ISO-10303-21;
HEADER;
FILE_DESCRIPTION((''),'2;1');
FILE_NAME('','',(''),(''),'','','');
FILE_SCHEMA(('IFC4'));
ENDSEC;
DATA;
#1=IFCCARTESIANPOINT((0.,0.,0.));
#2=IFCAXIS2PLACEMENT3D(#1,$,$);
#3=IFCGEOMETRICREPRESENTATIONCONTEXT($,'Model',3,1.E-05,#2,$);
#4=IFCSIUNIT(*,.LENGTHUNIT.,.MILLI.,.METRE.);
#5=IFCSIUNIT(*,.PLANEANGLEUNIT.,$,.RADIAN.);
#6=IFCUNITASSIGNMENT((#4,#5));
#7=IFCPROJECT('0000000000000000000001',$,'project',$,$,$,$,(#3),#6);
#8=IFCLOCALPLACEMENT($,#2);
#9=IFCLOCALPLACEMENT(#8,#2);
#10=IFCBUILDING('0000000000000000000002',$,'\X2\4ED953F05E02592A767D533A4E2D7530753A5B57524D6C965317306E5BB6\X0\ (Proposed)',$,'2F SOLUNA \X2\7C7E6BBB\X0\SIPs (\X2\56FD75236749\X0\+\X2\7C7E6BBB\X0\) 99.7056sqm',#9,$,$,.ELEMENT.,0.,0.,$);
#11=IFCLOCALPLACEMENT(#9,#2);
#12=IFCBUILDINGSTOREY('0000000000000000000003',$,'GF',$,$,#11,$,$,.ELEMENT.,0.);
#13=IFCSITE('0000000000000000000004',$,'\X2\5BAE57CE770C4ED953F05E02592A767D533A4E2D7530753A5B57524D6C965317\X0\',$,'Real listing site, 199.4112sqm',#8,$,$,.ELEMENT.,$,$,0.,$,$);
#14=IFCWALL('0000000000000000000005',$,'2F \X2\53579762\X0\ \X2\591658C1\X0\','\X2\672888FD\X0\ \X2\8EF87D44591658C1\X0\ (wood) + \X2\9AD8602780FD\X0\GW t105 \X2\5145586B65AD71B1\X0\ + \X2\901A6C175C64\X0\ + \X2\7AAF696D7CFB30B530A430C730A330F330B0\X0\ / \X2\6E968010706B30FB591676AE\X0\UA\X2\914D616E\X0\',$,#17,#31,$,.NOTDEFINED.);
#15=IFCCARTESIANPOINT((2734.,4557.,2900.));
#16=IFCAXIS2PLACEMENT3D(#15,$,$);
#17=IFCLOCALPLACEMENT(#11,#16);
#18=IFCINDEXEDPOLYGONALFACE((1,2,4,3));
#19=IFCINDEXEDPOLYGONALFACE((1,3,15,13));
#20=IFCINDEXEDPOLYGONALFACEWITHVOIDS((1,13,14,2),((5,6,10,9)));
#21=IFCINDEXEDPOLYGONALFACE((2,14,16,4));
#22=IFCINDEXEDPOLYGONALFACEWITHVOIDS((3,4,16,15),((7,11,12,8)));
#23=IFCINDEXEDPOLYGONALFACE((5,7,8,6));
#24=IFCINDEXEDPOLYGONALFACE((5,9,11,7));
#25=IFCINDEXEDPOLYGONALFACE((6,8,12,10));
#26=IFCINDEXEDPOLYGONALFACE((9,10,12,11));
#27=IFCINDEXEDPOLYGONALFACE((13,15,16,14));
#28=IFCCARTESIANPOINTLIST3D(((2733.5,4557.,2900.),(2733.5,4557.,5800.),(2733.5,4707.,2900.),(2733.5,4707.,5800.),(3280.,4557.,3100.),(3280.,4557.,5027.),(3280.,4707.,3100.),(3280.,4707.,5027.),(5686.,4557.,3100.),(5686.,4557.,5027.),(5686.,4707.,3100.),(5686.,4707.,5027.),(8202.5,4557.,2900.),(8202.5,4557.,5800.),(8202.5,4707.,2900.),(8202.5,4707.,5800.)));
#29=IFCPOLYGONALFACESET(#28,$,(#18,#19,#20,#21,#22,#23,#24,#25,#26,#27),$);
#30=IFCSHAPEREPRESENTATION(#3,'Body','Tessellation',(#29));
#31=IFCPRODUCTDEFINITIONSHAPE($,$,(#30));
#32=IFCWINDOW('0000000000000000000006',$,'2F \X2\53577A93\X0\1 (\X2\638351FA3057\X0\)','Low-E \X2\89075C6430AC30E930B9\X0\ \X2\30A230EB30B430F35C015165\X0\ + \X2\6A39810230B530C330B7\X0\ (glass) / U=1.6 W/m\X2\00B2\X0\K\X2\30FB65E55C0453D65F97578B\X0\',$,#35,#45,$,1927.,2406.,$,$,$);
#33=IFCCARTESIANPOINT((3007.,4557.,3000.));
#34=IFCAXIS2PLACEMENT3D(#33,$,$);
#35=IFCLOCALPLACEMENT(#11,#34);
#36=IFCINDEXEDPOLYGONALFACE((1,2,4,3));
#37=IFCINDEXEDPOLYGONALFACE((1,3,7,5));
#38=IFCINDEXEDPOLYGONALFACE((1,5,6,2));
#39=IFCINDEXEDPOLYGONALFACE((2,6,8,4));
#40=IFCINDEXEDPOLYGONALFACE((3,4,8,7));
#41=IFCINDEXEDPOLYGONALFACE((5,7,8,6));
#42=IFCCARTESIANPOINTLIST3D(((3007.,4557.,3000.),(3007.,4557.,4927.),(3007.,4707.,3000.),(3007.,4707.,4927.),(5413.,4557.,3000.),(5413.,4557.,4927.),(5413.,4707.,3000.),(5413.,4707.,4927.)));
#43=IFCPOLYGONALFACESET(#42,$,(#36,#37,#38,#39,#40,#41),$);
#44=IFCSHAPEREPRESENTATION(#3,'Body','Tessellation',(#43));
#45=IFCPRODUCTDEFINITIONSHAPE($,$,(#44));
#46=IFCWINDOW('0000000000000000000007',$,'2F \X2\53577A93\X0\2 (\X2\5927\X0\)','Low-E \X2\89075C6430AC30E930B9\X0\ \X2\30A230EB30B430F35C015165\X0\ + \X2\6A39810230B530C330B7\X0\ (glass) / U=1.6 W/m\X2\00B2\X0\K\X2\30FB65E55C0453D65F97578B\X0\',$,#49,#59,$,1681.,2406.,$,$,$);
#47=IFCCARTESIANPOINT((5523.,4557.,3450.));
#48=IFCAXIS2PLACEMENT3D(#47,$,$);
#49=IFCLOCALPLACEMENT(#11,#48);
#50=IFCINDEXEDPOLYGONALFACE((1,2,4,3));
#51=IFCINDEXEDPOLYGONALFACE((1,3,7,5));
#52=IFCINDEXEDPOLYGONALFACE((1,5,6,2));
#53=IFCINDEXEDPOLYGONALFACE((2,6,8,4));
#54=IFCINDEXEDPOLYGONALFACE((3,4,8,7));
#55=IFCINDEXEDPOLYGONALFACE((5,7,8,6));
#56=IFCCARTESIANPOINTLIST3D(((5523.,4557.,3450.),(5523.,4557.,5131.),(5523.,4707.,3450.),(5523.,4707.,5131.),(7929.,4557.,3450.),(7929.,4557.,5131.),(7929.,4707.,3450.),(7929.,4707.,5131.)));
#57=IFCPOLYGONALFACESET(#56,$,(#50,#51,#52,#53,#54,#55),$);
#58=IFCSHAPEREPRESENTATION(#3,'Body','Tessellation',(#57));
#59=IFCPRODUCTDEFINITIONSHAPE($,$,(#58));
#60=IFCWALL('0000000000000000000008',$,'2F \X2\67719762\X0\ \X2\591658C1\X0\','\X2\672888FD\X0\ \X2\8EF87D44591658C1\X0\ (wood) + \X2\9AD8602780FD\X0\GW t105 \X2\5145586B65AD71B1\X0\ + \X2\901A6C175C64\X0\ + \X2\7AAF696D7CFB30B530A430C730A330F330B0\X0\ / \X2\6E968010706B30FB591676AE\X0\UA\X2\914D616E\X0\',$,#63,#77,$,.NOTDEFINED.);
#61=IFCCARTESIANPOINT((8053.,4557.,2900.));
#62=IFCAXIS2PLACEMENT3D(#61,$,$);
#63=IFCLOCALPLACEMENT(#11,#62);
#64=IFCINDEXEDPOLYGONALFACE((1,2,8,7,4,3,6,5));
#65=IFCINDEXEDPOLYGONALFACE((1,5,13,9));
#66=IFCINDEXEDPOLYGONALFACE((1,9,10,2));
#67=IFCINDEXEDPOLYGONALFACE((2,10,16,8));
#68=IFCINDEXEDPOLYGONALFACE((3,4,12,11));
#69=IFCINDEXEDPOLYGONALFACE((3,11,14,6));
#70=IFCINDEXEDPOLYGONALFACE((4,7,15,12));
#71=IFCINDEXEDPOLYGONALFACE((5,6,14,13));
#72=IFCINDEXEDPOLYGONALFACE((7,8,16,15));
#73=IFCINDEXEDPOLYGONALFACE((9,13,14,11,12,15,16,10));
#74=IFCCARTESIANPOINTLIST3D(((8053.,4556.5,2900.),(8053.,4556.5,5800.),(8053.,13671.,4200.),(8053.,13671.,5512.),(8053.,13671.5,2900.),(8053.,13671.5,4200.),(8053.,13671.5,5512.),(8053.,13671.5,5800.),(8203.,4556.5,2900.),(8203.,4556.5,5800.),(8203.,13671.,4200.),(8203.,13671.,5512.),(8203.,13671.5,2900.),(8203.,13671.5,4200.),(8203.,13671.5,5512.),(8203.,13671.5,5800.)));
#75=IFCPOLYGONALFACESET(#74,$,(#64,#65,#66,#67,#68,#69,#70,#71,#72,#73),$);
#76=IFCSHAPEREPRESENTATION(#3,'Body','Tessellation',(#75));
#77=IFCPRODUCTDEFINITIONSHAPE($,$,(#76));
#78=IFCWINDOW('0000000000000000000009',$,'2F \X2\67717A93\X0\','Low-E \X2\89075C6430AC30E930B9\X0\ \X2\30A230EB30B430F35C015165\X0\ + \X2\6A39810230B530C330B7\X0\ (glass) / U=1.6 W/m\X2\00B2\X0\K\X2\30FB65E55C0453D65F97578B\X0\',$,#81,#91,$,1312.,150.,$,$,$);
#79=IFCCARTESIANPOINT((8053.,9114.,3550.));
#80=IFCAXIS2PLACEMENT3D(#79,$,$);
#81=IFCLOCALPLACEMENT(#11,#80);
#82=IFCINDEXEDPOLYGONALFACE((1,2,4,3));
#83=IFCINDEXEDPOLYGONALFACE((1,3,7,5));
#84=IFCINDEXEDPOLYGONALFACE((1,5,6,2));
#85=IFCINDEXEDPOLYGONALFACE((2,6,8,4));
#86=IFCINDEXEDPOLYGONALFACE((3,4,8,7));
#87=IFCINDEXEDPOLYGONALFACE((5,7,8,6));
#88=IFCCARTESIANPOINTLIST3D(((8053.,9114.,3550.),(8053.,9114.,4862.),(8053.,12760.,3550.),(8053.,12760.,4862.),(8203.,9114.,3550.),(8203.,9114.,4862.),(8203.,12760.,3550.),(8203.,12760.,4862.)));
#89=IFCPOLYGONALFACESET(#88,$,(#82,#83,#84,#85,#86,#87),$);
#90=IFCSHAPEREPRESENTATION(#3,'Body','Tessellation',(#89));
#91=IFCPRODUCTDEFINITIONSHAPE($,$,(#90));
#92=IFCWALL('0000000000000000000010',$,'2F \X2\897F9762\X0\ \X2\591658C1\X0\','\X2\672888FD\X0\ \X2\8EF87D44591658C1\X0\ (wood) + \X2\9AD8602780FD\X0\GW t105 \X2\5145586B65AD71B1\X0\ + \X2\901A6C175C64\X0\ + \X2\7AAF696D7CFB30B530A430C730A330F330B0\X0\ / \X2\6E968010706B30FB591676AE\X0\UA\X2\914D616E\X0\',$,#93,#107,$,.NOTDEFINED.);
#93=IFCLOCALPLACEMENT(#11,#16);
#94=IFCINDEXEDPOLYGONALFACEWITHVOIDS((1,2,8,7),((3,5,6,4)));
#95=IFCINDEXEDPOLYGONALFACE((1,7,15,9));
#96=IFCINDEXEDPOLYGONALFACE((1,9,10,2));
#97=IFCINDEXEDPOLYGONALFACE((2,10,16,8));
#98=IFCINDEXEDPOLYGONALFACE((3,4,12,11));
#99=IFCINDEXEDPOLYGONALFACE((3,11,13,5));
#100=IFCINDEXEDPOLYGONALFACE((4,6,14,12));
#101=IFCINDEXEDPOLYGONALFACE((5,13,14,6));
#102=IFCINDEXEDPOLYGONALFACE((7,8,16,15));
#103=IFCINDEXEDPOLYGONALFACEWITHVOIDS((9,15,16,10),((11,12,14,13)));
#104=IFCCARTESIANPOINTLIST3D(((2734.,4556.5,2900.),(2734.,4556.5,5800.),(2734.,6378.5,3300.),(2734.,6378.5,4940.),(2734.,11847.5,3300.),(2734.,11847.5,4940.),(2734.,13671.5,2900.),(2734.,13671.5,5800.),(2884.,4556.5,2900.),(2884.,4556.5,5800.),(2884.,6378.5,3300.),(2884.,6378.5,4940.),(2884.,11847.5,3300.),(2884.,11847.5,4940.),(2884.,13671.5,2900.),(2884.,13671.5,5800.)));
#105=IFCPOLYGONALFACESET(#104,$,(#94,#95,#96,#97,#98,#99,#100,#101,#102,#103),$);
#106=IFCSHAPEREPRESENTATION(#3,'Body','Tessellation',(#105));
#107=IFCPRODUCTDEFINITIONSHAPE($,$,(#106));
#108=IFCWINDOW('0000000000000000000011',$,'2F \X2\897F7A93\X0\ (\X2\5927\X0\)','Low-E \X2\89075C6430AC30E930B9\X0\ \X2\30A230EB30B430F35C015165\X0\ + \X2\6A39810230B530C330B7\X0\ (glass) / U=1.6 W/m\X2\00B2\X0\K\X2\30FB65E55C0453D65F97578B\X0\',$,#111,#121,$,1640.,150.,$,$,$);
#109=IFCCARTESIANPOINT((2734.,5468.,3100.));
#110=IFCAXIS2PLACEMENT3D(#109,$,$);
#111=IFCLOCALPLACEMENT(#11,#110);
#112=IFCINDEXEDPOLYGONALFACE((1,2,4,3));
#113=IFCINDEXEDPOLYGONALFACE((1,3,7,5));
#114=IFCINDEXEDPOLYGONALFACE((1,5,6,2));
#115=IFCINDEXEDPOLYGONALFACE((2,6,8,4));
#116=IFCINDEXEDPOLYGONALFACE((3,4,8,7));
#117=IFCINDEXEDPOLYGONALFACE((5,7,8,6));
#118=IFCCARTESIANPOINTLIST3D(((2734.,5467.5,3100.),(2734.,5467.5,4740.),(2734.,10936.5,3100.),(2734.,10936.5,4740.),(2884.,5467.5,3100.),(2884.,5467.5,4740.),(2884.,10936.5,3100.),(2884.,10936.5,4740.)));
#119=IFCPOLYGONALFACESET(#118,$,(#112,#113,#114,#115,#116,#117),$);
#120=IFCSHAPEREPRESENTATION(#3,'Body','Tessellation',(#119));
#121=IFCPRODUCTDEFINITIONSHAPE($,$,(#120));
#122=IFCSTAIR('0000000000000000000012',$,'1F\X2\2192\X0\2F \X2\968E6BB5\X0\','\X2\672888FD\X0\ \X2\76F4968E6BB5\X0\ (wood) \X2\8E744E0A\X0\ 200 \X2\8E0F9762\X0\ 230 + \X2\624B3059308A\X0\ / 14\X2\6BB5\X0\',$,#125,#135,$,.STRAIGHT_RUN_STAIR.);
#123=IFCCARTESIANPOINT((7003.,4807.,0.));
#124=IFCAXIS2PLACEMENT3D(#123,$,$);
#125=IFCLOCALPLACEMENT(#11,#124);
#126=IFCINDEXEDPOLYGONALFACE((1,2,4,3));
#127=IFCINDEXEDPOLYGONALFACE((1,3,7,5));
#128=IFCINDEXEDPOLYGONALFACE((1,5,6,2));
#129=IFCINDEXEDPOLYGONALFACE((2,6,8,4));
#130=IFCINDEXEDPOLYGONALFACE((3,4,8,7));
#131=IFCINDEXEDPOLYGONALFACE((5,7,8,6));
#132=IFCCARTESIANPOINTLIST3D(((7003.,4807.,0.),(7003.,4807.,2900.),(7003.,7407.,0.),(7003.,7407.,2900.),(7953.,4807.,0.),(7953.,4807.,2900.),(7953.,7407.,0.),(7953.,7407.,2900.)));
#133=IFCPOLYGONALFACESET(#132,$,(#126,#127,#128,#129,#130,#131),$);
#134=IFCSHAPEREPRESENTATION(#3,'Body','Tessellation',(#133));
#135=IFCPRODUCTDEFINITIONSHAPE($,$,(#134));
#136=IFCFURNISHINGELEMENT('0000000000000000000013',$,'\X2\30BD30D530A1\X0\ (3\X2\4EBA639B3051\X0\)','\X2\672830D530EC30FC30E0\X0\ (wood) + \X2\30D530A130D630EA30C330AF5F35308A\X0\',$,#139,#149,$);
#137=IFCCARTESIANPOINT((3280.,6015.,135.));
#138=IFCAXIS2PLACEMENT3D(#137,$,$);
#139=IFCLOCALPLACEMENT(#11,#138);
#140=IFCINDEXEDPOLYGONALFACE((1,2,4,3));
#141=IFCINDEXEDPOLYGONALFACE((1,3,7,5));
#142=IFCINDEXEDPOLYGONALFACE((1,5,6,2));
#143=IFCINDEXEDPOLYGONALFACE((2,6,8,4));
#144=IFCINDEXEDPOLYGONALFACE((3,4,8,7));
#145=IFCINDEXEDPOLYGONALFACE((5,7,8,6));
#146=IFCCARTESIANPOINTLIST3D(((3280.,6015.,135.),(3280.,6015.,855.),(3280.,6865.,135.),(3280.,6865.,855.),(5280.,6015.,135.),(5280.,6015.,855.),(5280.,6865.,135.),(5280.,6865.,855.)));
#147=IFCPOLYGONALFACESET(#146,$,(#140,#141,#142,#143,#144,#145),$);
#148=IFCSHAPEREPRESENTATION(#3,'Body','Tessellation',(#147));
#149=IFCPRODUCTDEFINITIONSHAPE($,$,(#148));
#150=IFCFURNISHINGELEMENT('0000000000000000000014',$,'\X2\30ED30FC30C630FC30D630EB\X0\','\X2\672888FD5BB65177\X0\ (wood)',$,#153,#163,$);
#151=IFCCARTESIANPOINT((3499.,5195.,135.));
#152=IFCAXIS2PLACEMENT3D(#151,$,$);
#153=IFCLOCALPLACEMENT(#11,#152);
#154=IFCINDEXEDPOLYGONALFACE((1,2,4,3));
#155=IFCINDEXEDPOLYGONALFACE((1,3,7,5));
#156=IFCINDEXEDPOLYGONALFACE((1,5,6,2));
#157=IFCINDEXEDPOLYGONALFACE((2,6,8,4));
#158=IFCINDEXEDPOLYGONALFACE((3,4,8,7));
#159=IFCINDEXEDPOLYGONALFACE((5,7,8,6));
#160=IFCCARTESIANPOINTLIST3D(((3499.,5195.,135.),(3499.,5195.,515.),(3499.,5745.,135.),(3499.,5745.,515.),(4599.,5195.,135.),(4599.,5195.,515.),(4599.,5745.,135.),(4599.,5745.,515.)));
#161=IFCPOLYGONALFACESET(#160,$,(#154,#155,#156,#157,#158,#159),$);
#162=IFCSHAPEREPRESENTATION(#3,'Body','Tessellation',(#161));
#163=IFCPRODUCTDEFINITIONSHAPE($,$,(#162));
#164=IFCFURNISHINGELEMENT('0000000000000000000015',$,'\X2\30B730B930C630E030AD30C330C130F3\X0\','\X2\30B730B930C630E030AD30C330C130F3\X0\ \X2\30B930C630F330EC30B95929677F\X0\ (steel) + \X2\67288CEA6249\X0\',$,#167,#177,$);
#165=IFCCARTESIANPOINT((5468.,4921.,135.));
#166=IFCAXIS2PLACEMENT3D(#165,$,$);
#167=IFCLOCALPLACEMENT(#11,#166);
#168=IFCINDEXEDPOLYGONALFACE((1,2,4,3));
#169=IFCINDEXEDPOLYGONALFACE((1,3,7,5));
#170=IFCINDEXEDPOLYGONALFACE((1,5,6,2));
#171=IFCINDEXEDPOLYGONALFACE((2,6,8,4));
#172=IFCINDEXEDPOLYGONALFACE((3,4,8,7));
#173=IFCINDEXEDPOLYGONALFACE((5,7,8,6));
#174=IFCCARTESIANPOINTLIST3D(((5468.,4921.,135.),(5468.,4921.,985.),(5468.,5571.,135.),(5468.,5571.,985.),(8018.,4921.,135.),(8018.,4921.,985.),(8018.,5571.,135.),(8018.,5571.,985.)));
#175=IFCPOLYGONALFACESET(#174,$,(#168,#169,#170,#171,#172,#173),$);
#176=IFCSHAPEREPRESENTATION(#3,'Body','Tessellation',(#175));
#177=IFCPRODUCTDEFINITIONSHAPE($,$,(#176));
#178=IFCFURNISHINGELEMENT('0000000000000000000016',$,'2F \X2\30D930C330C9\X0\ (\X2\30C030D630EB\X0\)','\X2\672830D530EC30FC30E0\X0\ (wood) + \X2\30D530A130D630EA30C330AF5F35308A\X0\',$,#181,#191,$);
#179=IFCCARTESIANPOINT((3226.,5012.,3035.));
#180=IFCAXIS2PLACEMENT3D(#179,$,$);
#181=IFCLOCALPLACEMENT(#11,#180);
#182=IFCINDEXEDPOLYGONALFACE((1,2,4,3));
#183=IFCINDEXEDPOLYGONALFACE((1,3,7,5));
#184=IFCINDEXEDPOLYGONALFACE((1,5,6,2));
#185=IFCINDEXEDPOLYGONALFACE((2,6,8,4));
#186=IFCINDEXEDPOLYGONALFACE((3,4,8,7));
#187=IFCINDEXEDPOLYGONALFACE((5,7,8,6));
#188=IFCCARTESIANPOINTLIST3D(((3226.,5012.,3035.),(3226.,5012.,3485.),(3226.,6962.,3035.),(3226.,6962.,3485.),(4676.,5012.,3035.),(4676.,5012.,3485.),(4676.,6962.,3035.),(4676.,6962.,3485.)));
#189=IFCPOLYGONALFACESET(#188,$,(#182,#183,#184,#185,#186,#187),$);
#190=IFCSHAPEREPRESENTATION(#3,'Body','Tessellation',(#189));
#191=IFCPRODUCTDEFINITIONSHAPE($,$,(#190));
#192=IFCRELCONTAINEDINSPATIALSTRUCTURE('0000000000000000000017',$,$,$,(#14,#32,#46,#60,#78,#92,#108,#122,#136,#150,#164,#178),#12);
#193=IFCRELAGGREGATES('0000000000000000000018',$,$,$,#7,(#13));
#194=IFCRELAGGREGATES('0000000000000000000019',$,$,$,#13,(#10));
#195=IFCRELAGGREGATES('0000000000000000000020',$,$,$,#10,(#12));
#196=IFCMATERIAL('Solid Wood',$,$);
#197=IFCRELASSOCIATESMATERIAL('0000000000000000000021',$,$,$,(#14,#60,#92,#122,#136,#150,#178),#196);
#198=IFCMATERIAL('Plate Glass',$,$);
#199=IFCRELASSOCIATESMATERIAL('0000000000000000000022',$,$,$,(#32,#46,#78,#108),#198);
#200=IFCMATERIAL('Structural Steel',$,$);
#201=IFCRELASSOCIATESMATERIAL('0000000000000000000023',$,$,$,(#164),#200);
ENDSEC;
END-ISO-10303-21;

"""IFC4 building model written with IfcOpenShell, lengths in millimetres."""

from ifc_helpers import new_model, si_unit, frame, frame_2d, origin, place, context, project, spatial, rectangle, extrude, material, element, fill, save


model = new_model("IFC4")

# Units and contexts
model_context = context("Model", 3, precision=1e-05, world=origin())
ifc_project = project(units=[si_unit("LENGTHUNIT", "METRE", prefix="MILLI"), si_unit("PLANEANGLEUNIT", "RADIAN")], contexts=[model_context])

# Site, building, storey
site_placement = place(None, origin())
site = spatial("IfcSite", under=ifc_project, at=site_placement, Name="宮城県仙台市太白区中田町字前沖北", ObjectType="Real listing site, 199.4112sqm", CompositionType="ELEMENT", RefElevation=0.0)
building_placement = place(site_placement, origin())
building = spatial("IfcBuilding", under=site, at=building_placement, Name="仙台市太白区中田町字前沖北の家 (Proposed)", ObjectType="2F SOLUNA 籾殻SIPs (国産杉+籾殻) 99.7056sqm", CompositionType="ELEMENT", ElevationOfRefHeight=0.0, ElevationOfTerrain=0.0)
storey_placement = place(building_placement, origin())
storey = spatial("IfcBuildingStorey", under=building, at=storey_placement, Name="GF", CompositionType="ELEMENT", Elevation=0.0)

# Shared definitions
ifc_material_1 = material(Name="Solid Wood")

# Shared definitions
ifc_material_2 = material(Name="Plate Glass")

# Wall, openings, windows
wall_1_placement = place(storey_placement, frame((2734.0, 4557.0, 2900.0)))
wall_1 = element("IfcWall", 1, at=wall_1_placement, inside=storey, material=ifc_material_1, Name="2F 南面 外壁", Description="木製 軸組外壁 (wood) + 高性能GW t105 充填断熱 + 通気層 + 窯業系サイディング / 準耐火・外皮UA配慮", PredefinedType="NOTDEFINED", context=model_context, shape_type="SweptSolid", body=[
    extrude(rectangle(XDim=5469.0, YDim=150.0, at=frame_2d((2734.0, 75.0))), frame((2734.0, 4557.0, 2900.0)), (0.0, 0.0, 1.0), 2900.0),
])
opening_1_placement = place(storey_placement, frame((3007.0, 4557.0, 3000.0)))
opening_1 = element("IfcOpeningElement", 2, at=opening_1_placement, cuts=wall_1, PredefinedType="NOTDEFINED", context=model_context, shape_type="SweptSolid", body=[
    extrude(rectangle(XDim=2406.0, YDim=150.0, at=frame_2d((1203.0, 75.0))), frame((3007.0, 4557.0, 3000.0)), (0.0, 0.0, 1.0), 1927.0),
])
opening_2_placement = place(storey_placement, frame((5523.0, 4557.0, 3450.0)))
opening_2 = element("IfcOpeningElement", 3, at=opening_2_placement, cuts=wall_1, PredefinedType="NOTDEFINED", context=model_context, shape_type="SweptSolid", body=[
    extrude(rectangle(XDim=2406.0, YDim=150.0, at=frame_2d((1203.0, 75.0))), frame((5523.0, 4557.0, 3450.0)), (0.0, 0.0, 1.0), 1681.0),
])
window_1_placement = place(storey_placement, frame((3007.0, 4557.0, 3000.0)))
window_1 = element("IfcWindow", 4, at=window_1_placement, inside=storey, material=ifc_material_2, Name="2F 南窓1 (掃出し)", Description="Low-E 複層ガラス アルゴン封入 + 樹脂サッシ (glass) / U=1.6 W/m²K・日射取得型", OverallHeight=1927.0, OverallWidth=2406.0, context=model_context, shape_type="SweptSolid", body=[
    extrude(rectangle(XDim=2406.0, YDim=150.0, at=frame_2d((1203.0, 75.0))), frame((3007.0, 4557.0, 3000.0)), (0.0, 0.0, 1.0), 1927.0),
])
fill(opening_1, window_1)
window_2_placement = place(storey_placement, frame((5523.0, 4557.0, 3450.0)))
window_2 = element("IfcWindow", 5, at=window_2_placement, inside=storey, material=ifc_material_2, Name="2F 南窓2 (大)", Description="Low-E 複層ガラス アルゴン封入 + 樹脂サッシ (glass) / U=1.6 W/m²K・日射取得型", OverallHeight=1681.0, OverallWidth=2406.0, context=model_context, shape_type="SweptSolid", body=[
    extrude(rectangle(XDim=2406.0, YDim=150.0, at=frame_2d((1203.0, 75.0))), frame((5523.0, 4557.0, 3450.0)), (0.0, 0.0, 1.0), 1681.0),
])
fill(opening_2, window_2)

# Walls, openings, windows
wall_2_placement = place(storey_placement, frame((8053.0, 4557.0, 2900.0)))
wall_2 = element("IfcWall", 6, at=wall_2_placement, inside=storey, material=ifc_material_1, Name="2F 東面 外壁", Description="木製 軸組外壁 (wood) + 高性能GW t105 充填断熱 + 通気層 + 窯業系サイディング / 準耐火・外皮UA配慮", PredefinedType="NOTDEFINED", context=model_context, shape_type="SweptSolid", body=[
    extrude(rectangle(XDim=150.0, YDim=9115.0, at=frame_2d((75.0, 4557.0))), frame((8053.0, 4557.0, 2900.0)), (0.0, 0.0, 1.0), 2900.0),
])
opening_3_placement = place(storey_placement, frame((8053.0, 9114.0, 3550.0)))
opening_3 = element("IfcOpeningElement", 7, at=opening_3_placement, cuts=wall_2, PredefinedType="NOTDEFINED", context=model_context, shape_type="SweptSolid", body=[
    extrude(rectangle(XDim=150.0, YDim=3646.0, at=frame_2d((75.0, 1823.0))), frame((8053.0, 9114.0, 3550.0)), (0.0, 0.0, 1.0), 1312.0),
])
window_3_placement = place(storey_placement, frame((8053.0, 9114.0, 3550.0)))
window_3 = element("IfcWindow", 8, at=window_3_placement, inside=storey, material=ifc_material_2, Name="2F 東窓", Description="Low-E 複層ガラス アルゴン封入 + 樹脂サッシ (glass) / U=1.6 W/m²K・日射取得型", OverallHeight=1312.0, OverallWidth=150.0, context=model_context, shape_type="SweptSolid", body=[
    extrude(rectangle(XDim=150.0, YDim=3646.0, at=frame_2d((75.0, 1823.0))), frame((8053.0, 9114.0, 3550.0)), (0.0, 0.0, 1.0), 1312.0),
])
fill(opening_3, window_3)
wall_3_placement = place(storey_placement, frame((2734.0, 4557.0, 2900.0)))
wall_3 = element("IfcWall", 9, at=wall_3_placement, inside=storey, material=ifc_material_1, Name="2F 西面 外壁", Description="木製 軸組外壁 (wood) + 高性能GW t105 充填断熱 + 通気層 + 窯業系サイディング / 準耐火・外皮UA配慮", PredefinedType="NOTDEFINED", context=model_context, shape_type="SweptSolid", body=[
    extrude(rectangle(XDim=150.0, YDim=9115.0, at=frame_2d((75.0, 4557.0))), frame((2734.0, 4557.0, 2900.0)), (0.0, 0.0, 1.0), 2900.0),
])
opening_4_placement = place(storey_placement, frame((2734.0, 5468.0, 3100.0)))
opening_4 = element("IfcOpeningElement", 10, at=opening_4_placement, cuts=wall_3, PredefinedType="NOTDEFINED", context=model_context, shape_type="SweptSolid", body=[
    extrude(rectangle(XDim=150.0, YDim=5469.0, at=frame_2d((75.0, 2734.0))), frame((2734.0, 5468.0, 3100.0)), (0.0, 0.0, 1.0), 1640.0),
])
window_4_placement = place(storey_placement, frame((2734.0, 5468.0, 3100.0)))
window_4 = element("IfcWindow", 11, at=window_4_placement, inside=storey, material=ifc_material_2, Name="2F 西窓 (大)", Description="Low-E 複層ガラス アルゴン封入 + 樹脂サッシ (glass) / U=1.6 W/m²K・日射取得型", OverallHeight=1640.0, OverallWidth=150.0, context=model_context, shape_type="SweptSolid", body=[
    extrude(rectangle(XDim=150.0, YDim=5469.0, at=frame_2d((75.0, 2734.0))), frame((2734.0, 5468.0, 3100.0)), (0.0, 0.0, 1.0), 1640.0),
])
fill(opening_4, window_4)

# Stair
stair_placement = place(storey_placement, frame((7003.0, 4807.0, 0.0)))
element("IfcStair", 12, at=stair_placement, inside=storey, material=ifc_material_1, Name="1F→2F 階段", Description="木製 直階段 (wood) 蹴上 200 踏面 230 + 手すり / 14段", PredefinedType="STRAIGHT_RUN_STAIR", context=model_context, shape_type="SweptSolid", body=[
    extrude(rectangle(XDim=950.0, YDim=2600.0, at=frame_2d((475.0, 1300.0))), frame((7003.0, 4807.0, 0.0)), (0.0, 0.0, 1.0), 2900.0),
])

# Shared definitions
ifc_material_3 = material(Name="Structural Steel")

# Furnishing elements
furnishing_1_placement = place(storey_placement, frame((3280.0, 6015.0, 135.0)))
element("IfcFurnishingElement", 13, at=furnishing_1_placement, inside=storey, material=ifc_material_1, Name="ソファ (3人掛け)", Description="木フレーム (wood) + ファブリック張り", context=model_context, shape_type="SweptSolid", body=[
    extrude(rectangle(XDim=2000.0, YDim=850.0, at=frame_2d((1000.0, 425.0))), frame((3280.0, 6015.0, 135.0)), (0.0, 0.0, 1.0), 720.0),
])
furnishing_2_placement = place(storey_placement, frame((3499.0, 5195.0, 135.0)))
element("IfcFurnishingElement", 14, at=furnishing_2_placement, inside=storey, material=ifc_material_1, Name="ローテーブル", Description="木製家具 (wood)", context=model_context, shape_type="SweptSolid", body=[
    extrude(rectangle(XDim=1100.0, YDim=550.0, at=frame_2d((550.0, 275.0))), frame((3499.0, 5195.0, 135.0)), (0.0, 0.0, 1.0), 380.0),
])
furnishing_3_placement = place(storey_placement, frame((5468.0, 4921.0, 135.0)))
element("IfcFurnishingElement", 15, at=furnishing_3_placement, inside=storey, material=ifc_material_3, Name="システムキッチン", Description="システムキッチン ステンレス天板 (steel) + 木質扉", context=model_context, shape_type="SweptSolid", body=[
    extrude(rectangle(XDim=2550.0, YDim=650.0, at=frame_2d((1275.0, 325.0))), frame((5468.0, 4921.0, 135.0)), (0.0, 0.0, 1.0), 850.0),
])
furnishing_4_placement = place(storey_placement, frame((3226.0, 5012.0, 3035.0)))
element("IfcFurnishingElement", 16, at=furnishing_4_placement, inside=storey, material=ifc_material_1, Name="2F ベッド (ダブル)", Description="木フレーム (wood) + ファブリック張り", context=model_context, shape_type="SweptSolid", body=[
    extrude(rectangle(XDim=1450.0, YDim=1950.0, at=frame_2d((725.0, 975.0))), frame((3226.0, 5012.0, 3035.0)), (0.0, 0.0, 1.0), 450.0),
])

save(model, "model.ifc")
